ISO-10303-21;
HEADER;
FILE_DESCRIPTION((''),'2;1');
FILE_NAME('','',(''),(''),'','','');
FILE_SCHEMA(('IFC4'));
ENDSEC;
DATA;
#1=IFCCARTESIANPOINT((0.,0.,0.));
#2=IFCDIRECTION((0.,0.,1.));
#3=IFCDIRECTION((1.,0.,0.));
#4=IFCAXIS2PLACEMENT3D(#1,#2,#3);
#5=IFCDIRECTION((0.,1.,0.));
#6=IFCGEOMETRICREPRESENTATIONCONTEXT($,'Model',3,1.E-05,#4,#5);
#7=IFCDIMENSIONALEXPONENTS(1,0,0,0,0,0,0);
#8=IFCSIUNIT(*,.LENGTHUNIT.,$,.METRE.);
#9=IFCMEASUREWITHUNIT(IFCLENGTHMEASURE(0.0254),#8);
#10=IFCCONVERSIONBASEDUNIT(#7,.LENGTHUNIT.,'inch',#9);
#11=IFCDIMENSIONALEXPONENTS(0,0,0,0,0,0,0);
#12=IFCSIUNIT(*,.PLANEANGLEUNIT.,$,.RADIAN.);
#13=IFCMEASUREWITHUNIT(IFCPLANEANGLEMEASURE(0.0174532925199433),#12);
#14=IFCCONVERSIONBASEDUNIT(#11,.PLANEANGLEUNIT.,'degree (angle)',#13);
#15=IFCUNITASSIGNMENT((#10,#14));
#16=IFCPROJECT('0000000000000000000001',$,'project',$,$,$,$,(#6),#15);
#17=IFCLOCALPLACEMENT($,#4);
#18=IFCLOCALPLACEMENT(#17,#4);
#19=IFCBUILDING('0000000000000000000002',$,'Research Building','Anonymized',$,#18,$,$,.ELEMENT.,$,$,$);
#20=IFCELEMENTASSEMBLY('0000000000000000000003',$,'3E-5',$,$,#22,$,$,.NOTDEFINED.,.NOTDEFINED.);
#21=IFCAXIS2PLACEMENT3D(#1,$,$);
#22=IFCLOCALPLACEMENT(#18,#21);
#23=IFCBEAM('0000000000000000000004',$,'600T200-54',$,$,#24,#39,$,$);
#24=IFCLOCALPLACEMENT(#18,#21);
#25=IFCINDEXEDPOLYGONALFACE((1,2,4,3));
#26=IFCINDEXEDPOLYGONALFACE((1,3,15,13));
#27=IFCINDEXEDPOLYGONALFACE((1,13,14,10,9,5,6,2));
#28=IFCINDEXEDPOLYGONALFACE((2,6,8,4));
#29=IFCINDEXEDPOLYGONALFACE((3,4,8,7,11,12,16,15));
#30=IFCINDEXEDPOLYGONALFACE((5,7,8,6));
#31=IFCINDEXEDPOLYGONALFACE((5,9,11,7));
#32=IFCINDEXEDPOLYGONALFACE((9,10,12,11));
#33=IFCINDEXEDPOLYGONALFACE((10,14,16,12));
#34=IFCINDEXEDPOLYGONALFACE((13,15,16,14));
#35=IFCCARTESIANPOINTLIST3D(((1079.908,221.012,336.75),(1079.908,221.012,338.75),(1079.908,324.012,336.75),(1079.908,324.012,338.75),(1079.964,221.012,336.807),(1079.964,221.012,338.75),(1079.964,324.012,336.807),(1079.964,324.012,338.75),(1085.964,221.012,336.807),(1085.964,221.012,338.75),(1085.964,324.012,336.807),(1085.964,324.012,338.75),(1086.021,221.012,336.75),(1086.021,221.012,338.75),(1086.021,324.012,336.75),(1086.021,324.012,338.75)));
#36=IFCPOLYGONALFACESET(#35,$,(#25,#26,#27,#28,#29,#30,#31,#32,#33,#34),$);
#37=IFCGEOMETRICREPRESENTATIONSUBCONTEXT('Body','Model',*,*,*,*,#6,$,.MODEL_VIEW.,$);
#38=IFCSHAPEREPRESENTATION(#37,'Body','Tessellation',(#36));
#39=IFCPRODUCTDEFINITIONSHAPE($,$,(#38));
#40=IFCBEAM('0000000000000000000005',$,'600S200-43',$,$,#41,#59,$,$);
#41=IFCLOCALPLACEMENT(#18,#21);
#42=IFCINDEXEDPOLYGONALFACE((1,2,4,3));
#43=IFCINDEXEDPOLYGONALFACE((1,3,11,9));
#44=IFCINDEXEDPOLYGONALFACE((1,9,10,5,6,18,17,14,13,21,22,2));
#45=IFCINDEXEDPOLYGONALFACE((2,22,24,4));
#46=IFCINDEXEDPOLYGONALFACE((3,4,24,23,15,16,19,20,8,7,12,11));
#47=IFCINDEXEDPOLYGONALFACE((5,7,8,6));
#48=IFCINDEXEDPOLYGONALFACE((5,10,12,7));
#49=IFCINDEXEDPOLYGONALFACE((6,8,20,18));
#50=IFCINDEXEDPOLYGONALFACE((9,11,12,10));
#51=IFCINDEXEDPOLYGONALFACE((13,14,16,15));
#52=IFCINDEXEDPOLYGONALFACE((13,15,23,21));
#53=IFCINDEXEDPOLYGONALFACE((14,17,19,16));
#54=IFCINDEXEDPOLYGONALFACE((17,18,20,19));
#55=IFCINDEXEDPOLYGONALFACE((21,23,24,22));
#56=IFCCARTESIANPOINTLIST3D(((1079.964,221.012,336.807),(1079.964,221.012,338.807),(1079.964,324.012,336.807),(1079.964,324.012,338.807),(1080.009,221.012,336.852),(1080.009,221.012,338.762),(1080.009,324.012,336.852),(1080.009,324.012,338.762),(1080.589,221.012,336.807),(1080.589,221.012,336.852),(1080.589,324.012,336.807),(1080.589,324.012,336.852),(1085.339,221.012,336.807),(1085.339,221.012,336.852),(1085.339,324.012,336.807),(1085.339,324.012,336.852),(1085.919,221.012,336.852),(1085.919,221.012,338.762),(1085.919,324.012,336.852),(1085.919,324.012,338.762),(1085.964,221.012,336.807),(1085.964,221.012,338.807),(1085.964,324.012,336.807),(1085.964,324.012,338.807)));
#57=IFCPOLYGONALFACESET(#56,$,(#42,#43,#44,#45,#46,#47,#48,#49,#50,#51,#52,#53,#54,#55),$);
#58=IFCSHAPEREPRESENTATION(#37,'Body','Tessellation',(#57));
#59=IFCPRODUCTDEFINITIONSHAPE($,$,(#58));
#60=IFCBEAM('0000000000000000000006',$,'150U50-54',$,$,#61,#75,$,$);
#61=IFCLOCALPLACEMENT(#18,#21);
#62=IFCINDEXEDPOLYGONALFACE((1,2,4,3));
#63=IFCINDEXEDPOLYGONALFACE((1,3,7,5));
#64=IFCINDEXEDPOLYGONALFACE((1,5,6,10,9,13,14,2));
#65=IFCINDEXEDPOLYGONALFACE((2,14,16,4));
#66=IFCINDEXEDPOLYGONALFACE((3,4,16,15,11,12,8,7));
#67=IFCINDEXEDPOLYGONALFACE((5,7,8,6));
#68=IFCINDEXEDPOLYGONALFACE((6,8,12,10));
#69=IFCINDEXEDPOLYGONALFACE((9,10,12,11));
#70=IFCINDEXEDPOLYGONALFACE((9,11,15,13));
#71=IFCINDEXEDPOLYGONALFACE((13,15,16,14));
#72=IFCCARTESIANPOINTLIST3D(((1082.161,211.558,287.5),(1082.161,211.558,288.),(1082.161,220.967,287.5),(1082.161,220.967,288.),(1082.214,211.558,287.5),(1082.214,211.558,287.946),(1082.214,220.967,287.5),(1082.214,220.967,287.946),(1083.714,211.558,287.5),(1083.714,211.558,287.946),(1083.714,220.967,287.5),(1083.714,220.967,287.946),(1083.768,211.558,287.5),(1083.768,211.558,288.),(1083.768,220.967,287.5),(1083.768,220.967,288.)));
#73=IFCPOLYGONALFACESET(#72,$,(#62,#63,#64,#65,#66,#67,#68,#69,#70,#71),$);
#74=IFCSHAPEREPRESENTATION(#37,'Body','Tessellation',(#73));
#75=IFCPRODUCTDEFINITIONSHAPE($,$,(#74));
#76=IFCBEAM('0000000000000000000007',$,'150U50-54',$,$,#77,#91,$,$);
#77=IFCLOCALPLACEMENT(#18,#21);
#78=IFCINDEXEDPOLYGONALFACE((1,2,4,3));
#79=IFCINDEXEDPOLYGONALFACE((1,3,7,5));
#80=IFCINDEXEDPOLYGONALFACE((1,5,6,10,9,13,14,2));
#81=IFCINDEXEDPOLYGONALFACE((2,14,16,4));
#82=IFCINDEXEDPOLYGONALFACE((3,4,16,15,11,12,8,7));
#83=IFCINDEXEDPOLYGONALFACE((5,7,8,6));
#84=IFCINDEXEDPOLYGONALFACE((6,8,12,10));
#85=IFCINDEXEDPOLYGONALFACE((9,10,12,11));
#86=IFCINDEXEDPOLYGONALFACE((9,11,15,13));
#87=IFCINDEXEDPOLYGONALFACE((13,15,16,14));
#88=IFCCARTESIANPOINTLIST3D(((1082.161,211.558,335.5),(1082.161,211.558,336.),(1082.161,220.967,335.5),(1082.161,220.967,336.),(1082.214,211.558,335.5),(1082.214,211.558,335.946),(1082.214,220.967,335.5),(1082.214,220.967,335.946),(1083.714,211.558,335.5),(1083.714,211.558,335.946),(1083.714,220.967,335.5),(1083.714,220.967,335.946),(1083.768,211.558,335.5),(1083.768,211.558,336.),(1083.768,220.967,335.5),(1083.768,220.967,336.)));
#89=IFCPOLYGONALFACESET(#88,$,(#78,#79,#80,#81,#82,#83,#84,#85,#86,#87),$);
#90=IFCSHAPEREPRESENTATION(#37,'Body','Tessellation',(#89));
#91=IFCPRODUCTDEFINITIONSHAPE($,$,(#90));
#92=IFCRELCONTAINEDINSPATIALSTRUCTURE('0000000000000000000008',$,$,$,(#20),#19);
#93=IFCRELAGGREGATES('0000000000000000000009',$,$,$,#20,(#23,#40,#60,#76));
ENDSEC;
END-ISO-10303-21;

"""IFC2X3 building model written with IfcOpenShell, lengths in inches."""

from ifc_helpers import new_model, entity, si_unit, converted_unit, direction, frame, origin_with_axes, origin_2d_with_axis, place, context, subcontext, project, spatial, polyline, segment, composite_curve, c_section, outline, extrude, element, aggregate, save


model = new_model("IFC2X3")

# Units and contexts
model_context = context("Model", 3, precision=1e-05, world=origin_with_axes(), true_north=direction((0.0, 1.0, 0.0)))
body_context = subcontext(model_context, "Body", "Model", "MODEL_VIEW")
ifc_project = project(units=[converted_unit("LENGTHUNIT", "inch", entity("IfcLengthMeasure", 0.0254), si_unit("LENGTHUNIT", "METRE"), dimensions=[1, 0, 0, 0, 0, 0, 0]), converted_unit("PLANEANGLEUNIT", "degree (angle)", entity("IfcPlaneAngleMeasure", 0.0174532925199433), si_unit("PLANEANGLEUNIT", "RADIAN"), dimensions=[0, 0, 0, 0, 0, 0, 0])], contexts=[model_context])

# Building
placement = place(None, origin_with_axes())
building_placement = place(placement, origin_with_axes())
building = spatial("IfcBuilding", at=building_placement, Name="Research Building", Description="Anonymized", CompositionType="ELEMENT")

# Element assembly, beams
assembly_placement = place(building_placement, origin_with_axes())
assembly = element("IfcElementAssembly", 1, at=assembly_placement, inside=building, Name="3E-5", AssemblyPlace="NOTDEFINED", PredefinedType="NOTDEFINED")
beam_1_placement = place(assembly_placement, frame((1082.964, 221.012, 337.75), z_axis=(0.0, 1.0, 0.0), x_axis=(0.0, 0.0, 1.0)))
beam_1 = element("IfcBeam", 2, at=beam_1_placement, Name="600T200-54", context=body_context, shape_type="SweptSolid", body=[
    extrude(outline(composite_curve([segment(polyline([(-1.0, -3.057), (-1.0, 3.057), (1.0, 3.057), (1.0, 3.0), (-0.943, 3.0), (-0.943, -3.0), (1.0, -3.0), (1.0, -3.057), (-1.0, -3.057)]), True, "CONTINUOUS")], self_intersect=False)), frame((0.0, 0.0, 0.0), z_axis=(0.0, 0.0, 1.0), x_axis=(1.0, 0.0, 0.0)), (0.0, 0.0, 1.0), 103.0),
])
beam_2_placement = place(assembly_placement, frame((1082.964, 324.012, 337.807), z_axis=(0.0, -1.0, 0.0), x_axis=(0.0, 0.0, -1.0)))
beam_2 = element("IfcBeam", 3, at=beam_2_placement, Name="600S200-43", context=body_context, shape_type="SweptSolid", body=[
    extrude(c_section(Depth=6.0, Width=2.0, WallThickness=0.045, Girth=0.625, at=origin_2d_with_axis()), frame((0.0, 0.0, 0.0), z_axis=(0.0, 0.0, 1.0), x_axis=(1.0, 0.0, 0.0)), (0.0, 0.0, 1.0), 103.0),
])
beam_3_placement = place(assembly_placement, frame((1082.964, 220.967, 287.75), z_axis=(0.0, -1.0, 0.0), x_axis=(0.0, 0.0, -1.0)))
beam_3 = element("IfcBeam", 4, at=beam_3_placement, Name="150U50-54", context=body_context, shape_type="SweptSolid", body=[
    extrude(outline(composite_curve([segment(polyline([(-0.25, -0.804), (-0.25, 0.804), (0.25, 0.804), (0.25, 0.75), (-0.196, 0.75), (-0.196, -0.75), (0.25, -0.75), (0.25, -0.804), (-0.25, -0.804)]), True, "CONTINUOUS")], self_intersect=False)), frame((0.0, 0.0, 0.0), z_axis=(0.0, 0.0, 1.0), x_axis=(1.0, 0.0, 0.0)), (0.0, 0.0, 1.0), 9.41),
])
beam_4_placement = place(assembly_placement, frame((1082.964, 220.967, 335.75), z_axis=(0.0, -1.0, 0.0), x_axis=(0.0, 0.0, -1.0)))
beam_4 = element("IfcBeam", 5, at=beam_4_placement, Name="150U50-54", context=body_context, shape_type="SweptSolid", body=[
    extrude(outline(composite_curve([segment(polyline([(-0.25, -0.804), (-0.25, 0.804), (0.25, 0.804), (0.25, 0.75), (-0.196, 0.75), (-0.196, -0.75), (0.25, -0.75), (0.25, -0.804), (-0.25, -0.804)]), True, "CONTINUOUS")], self_intersect=False)), frame((0.0, 0.0, 0.0), z_axis=(0.0, 0.0, 1.0), x_axis=(1.0, 0.0, 0.0)), (0.0, 0.0, 1.0), 9.41),
])
aggregate(assembly, [beam_1, beam_2, beam_3, beam_4])

save(model, "model.ifc")
